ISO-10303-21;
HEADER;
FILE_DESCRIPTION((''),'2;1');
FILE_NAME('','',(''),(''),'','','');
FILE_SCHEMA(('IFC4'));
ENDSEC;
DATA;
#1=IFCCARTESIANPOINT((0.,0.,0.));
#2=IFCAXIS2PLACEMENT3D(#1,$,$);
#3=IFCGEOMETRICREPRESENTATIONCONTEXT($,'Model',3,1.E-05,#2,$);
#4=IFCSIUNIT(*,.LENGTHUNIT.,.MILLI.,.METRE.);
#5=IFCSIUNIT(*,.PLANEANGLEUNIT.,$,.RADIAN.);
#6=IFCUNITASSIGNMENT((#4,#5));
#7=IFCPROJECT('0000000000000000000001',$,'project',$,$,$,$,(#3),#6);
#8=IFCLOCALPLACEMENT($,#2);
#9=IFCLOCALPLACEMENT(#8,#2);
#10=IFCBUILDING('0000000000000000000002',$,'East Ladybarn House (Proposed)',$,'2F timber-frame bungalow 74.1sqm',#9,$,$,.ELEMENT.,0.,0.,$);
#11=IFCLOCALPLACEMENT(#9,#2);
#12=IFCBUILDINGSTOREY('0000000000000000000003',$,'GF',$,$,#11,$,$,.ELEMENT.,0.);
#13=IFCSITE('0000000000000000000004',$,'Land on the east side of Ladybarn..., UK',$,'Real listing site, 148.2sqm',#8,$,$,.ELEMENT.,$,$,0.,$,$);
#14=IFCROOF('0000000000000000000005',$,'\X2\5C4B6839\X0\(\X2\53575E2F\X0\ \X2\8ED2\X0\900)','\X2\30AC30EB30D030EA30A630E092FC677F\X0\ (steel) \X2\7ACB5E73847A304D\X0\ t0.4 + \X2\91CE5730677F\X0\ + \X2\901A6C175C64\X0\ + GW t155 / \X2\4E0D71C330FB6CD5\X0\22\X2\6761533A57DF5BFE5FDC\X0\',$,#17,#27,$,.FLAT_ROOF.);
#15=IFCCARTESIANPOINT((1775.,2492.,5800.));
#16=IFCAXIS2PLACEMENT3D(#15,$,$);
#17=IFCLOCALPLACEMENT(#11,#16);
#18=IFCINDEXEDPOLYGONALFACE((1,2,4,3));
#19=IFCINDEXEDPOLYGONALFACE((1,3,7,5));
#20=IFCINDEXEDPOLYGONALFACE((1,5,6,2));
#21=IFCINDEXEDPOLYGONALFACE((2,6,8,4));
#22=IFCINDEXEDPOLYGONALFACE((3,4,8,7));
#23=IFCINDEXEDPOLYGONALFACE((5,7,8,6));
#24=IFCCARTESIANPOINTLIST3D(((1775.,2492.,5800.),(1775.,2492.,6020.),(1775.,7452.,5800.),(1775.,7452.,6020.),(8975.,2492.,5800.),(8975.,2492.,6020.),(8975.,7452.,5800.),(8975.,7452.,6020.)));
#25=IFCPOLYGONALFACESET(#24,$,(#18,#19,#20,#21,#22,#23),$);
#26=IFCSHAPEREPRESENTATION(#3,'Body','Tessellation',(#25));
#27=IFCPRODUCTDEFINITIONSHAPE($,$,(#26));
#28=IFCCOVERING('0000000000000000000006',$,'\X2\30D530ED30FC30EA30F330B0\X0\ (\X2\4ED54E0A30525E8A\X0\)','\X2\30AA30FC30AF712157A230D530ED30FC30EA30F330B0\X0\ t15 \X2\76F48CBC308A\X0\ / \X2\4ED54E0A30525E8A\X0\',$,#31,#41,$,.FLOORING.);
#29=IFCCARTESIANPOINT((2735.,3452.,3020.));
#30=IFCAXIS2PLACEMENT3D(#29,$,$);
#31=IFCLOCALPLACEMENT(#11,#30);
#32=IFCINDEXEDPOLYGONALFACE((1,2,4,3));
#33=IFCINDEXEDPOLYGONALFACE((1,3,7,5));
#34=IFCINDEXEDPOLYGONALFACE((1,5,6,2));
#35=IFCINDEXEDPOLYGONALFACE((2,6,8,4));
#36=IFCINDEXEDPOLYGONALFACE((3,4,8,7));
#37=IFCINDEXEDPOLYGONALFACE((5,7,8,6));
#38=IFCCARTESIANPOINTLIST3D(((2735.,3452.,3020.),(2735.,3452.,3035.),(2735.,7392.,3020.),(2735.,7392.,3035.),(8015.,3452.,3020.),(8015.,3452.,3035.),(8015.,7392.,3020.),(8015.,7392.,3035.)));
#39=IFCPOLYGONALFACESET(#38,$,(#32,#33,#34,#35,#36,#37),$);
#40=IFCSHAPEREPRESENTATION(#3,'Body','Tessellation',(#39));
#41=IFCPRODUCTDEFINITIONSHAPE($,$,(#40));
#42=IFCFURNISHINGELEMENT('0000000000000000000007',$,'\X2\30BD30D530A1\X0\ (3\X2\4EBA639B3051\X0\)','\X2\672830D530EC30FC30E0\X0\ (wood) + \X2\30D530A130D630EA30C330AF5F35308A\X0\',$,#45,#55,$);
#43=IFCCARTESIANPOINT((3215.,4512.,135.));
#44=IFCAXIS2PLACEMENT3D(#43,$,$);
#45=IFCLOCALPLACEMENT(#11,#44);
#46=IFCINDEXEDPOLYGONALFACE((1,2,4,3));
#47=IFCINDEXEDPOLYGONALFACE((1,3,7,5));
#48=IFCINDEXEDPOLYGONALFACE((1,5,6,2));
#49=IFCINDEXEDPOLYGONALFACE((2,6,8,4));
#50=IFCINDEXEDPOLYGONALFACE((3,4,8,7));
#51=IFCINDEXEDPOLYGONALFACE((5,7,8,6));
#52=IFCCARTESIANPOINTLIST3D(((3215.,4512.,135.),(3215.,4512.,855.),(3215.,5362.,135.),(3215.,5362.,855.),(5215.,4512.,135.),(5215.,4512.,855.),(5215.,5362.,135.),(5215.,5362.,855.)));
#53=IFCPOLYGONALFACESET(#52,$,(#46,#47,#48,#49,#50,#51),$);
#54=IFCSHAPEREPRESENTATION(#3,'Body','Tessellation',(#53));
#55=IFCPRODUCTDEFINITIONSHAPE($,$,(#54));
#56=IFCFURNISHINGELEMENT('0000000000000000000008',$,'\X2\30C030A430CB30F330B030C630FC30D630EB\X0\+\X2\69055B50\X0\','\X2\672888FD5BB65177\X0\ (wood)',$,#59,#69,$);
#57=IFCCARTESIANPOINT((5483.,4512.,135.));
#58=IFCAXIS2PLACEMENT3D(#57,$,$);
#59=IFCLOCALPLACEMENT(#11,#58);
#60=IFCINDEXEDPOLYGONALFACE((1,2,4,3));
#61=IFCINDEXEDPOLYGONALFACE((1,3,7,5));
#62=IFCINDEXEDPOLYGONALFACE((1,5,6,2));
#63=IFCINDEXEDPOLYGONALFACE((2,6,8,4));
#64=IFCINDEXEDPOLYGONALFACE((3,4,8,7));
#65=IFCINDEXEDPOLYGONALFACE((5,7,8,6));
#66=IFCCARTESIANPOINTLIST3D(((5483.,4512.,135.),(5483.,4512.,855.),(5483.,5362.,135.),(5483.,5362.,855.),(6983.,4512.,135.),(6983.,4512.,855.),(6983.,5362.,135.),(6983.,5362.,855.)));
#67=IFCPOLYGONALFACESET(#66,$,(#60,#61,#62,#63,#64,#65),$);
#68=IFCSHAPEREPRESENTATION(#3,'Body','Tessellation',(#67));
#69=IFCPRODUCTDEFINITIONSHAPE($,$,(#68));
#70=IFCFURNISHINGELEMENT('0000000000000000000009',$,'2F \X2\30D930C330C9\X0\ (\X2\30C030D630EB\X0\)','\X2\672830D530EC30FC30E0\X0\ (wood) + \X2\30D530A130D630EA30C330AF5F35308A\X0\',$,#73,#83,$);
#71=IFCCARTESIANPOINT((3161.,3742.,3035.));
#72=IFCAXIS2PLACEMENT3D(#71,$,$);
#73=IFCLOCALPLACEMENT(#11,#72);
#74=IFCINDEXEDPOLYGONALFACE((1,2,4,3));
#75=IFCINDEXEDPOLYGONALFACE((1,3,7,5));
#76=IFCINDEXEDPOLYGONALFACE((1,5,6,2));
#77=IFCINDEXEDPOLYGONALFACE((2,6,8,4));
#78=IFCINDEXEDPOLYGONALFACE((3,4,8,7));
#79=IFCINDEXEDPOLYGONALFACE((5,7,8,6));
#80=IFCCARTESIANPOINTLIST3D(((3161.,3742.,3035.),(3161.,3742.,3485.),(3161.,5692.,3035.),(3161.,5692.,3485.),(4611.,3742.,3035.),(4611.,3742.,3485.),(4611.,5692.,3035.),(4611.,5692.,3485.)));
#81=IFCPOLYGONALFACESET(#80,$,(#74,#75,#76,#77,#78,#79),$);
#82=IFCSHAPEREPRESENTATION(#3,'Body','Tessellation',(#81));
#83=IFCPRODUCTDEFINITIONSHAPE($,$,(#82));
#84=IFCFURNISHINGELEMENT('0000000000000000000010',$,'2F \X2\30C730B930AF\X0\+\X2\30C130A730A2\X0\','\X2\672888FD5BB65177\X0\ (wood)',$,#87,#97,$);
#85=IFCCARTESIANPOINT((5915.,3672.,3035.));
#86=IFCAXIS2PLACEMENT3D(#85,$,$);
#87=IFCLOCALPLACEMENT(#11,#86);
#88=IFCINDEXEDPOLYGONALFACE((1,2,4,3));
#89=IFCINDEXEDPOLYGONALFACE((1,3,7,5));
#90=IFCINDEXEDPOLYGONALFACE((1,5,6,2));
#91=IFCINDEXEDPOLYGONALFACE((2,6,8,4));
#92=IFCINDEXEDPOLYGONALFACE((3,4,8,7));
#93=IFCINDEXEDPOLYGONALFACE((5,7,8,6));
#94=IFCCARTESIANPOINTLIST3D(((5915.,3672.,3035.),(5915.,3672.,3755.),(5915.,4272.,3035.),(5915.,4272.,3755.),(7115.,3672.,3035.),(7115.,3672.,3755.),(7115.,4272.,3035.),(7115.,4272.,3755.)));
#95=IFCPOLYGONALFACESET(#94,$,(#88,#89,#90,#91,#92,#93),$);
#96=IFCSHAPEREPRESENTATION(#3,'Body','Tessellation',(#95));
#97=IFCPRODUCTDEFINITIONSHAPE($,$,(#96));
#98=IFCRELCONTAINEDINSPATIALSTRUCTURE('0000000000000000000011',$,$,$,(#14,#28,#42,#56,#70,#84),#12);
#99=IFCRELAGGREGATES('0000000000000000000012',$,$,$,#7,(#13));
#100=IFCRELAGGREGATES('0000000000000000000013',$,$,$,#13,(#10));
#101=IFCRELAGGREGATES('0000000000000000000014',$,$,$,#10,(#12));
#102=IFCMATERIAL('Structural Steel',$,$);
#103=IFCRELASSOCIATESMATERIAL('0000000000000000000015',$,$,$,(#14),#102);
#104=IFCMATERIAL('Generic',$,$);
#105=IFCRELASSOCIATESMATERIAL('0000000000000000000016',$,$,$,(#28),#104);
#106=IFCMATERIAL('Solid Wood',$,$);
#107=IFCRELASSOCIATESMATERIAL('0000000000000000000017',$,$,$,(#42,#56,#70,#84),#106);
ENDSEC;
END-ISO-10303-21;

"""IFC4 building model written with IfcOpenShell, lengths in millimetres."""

from ifc_helpers import new_model, si_unit, frame, frame_2d, origin, place, context, project, spatial, rectangle, extrude, material, element, save


model = new_model("IFC4")

# Units and contexts
model_context = context("Model", 3, precision=1e-05, world=origin())
ifc_project = project(units=[si_unit("LENGTHUNIT", "METRE", prefix="MILLI"), si_unit("PLANEANGLEUNIT", "RADIAN")], contexts=[model_context])

# Site, building, storey
site_placement = place(None, origin())
site = spatial("IfcSite", under=ifc_project, at=site_placement, Name="Land on the east side of Ladybarn..., UK", ObjectType="Real listing site, 148.2sqm", CompositionType="ELEMENT", RefElevation=0.0)
building_placement = place(site_placement, origin())
building = spatial("IfcBuilding", under=site, at=building_placement, Name="East Ladybarn House (Proposed)", ObjectType="2F timber-frame bungalow 74.1sqm", CompositionType="ELEMENT", ElevationOfRefHeight=0.0, ElevationOfTerrain=0.0)
storey_placement = place(building_placement, origin())
storey = spatial("IfcBuildingStorey", under=building, at=storey_placement, Name="GF", CompositionType="ELEMENT", Elevation=0.0)

# Shared definitions
ifc_material_1 = material(Name="Solid Wood")

# Roof
ifc_material_2 = material(Name="Structural Steel")
for number, where, name in (
    (1, (1775.0, 2492.0, 5800.0), "屋根(南帯 軒900)"),
):
    element("IfcRoof", number, at=place(storey_placement, frame(where)), inside=storey, material=ifc_material_2, Name=name, Description="ガルバリウム鋼板 (steel) 立平葺き t0.4 + 野地板 + 通気層 + GW t155 / 不燃・法22条区域対応", PredefinedType="FLAT_ROOF", context=model_context, shape_type="SweptSolid", body=[
        extrude(rectangle(XDim=7200.0, YDim=4960.0, at=frame_2d((3600.0, 2480.0))), frame((1775.0, 2492.0, 5800.0)), (0.0, 0.0, 1.0), 220.0),
    ])

# Covering
ifc_material_3 = material(Name="Generic")
covering_placement = place(storey_placement, frame((2735.0, 3452.0, 3020.0)))
element("IfcCovering", 2, at=covering_placement, inside=storey, material=ifc_material_3, Name="フローリング (仕上げ床)", Description="オーク無垢フローリング t15 直貼り / 仕上げ床", PredefinedType="FLOORING", context=model_context, shape_type="SweptSolid", body=[
    extrude(rectangle(XDim=5280.0, YDim=3940.0, at=frame_2d((2640.0, 1970.0))), frame((2735.0, 3452.0, 3020.0)), (0.0, 0.0, 1.0), 15.0),
])

# Furnishing elements
furnishing_1_placement = place(storey_placement, frame((3215.0, 4512.0, 135.0)))
element("IfcFurnishingElement", 3, at=furnishing_1_placement, inside=storey, material=ifc_material_1, Name="ソファ (3人掛け)", Description="木フレーム (wood) + ファブリック張り", context=model_context, shape_type="SweptSolid", body=[
    extrude(rectangle(XDim=2000.0, YDim=850.0, at=frame_2d((1000.0, 425.0))), frame((3215.0, 4512.0, 135.0)), (0.0, 0.0, 1.0), 720.0),
])
furnishing_2_placement = place(storey_placement, frame((5483.0, 4512.0, 135.0)))
element("IfcFurnishingElement", 4, at=furnishing_2_placement, inside=storey, material=ifc_material_1, Name="ダイニングテーブル+椅子", Description="木製家具 (wood)", context=model_context, shape_type="SweptSolid", body=[
    extrude(rectangle(XDim=1500.0, YDim=850.0, at=frame_2d((750.0, 425.0))), frame((5483.0, 4512.0, 135.0)), (0.0, 0.0, 1.0), 720.0),
])
furnishing_3_placement = place(storey_placement, frame((3161.0, 3742.0, 3035.0)))
element("IfcFurnishingElement", 5, at=furnishing_3_placement, inside=storey, material=ifc_material_1, Name="2F ベッド (ダブル)", Description="木フレーム (wood) + ファブリック張り", context=model_context, shape_type="SweptSolid", body=[
    extrude(rectangle(XDim=1450.0, YDim=1950.0, at=frame_2d((725.0, 975.0))), frame((3161.0, 3742.0, 3035.0)), (0.0, 0.0, 1.0), 450.0),
])
furnishing_4_placement = place(storey_placement, frame((5915.0, 3672.0, 3035.0)))
element("IfcFurnishingElement", 6, at=furnishing_4_placement, inside=storey, material=ifc_material_1, Name="2F デスク+チェア", Description="木製家具 (wood)", context=model_context, shape_type="SweptSolid", body=[
    extrude(rectangle(XDim=1200.0, YDim=600.0, at=frame_2d((600.0, 300.0))), frame((5915.0, 3672.0, 3035.0)), (0.0, 0.0, 1.0), 720.0),
])

save(model, "model.ifc")
